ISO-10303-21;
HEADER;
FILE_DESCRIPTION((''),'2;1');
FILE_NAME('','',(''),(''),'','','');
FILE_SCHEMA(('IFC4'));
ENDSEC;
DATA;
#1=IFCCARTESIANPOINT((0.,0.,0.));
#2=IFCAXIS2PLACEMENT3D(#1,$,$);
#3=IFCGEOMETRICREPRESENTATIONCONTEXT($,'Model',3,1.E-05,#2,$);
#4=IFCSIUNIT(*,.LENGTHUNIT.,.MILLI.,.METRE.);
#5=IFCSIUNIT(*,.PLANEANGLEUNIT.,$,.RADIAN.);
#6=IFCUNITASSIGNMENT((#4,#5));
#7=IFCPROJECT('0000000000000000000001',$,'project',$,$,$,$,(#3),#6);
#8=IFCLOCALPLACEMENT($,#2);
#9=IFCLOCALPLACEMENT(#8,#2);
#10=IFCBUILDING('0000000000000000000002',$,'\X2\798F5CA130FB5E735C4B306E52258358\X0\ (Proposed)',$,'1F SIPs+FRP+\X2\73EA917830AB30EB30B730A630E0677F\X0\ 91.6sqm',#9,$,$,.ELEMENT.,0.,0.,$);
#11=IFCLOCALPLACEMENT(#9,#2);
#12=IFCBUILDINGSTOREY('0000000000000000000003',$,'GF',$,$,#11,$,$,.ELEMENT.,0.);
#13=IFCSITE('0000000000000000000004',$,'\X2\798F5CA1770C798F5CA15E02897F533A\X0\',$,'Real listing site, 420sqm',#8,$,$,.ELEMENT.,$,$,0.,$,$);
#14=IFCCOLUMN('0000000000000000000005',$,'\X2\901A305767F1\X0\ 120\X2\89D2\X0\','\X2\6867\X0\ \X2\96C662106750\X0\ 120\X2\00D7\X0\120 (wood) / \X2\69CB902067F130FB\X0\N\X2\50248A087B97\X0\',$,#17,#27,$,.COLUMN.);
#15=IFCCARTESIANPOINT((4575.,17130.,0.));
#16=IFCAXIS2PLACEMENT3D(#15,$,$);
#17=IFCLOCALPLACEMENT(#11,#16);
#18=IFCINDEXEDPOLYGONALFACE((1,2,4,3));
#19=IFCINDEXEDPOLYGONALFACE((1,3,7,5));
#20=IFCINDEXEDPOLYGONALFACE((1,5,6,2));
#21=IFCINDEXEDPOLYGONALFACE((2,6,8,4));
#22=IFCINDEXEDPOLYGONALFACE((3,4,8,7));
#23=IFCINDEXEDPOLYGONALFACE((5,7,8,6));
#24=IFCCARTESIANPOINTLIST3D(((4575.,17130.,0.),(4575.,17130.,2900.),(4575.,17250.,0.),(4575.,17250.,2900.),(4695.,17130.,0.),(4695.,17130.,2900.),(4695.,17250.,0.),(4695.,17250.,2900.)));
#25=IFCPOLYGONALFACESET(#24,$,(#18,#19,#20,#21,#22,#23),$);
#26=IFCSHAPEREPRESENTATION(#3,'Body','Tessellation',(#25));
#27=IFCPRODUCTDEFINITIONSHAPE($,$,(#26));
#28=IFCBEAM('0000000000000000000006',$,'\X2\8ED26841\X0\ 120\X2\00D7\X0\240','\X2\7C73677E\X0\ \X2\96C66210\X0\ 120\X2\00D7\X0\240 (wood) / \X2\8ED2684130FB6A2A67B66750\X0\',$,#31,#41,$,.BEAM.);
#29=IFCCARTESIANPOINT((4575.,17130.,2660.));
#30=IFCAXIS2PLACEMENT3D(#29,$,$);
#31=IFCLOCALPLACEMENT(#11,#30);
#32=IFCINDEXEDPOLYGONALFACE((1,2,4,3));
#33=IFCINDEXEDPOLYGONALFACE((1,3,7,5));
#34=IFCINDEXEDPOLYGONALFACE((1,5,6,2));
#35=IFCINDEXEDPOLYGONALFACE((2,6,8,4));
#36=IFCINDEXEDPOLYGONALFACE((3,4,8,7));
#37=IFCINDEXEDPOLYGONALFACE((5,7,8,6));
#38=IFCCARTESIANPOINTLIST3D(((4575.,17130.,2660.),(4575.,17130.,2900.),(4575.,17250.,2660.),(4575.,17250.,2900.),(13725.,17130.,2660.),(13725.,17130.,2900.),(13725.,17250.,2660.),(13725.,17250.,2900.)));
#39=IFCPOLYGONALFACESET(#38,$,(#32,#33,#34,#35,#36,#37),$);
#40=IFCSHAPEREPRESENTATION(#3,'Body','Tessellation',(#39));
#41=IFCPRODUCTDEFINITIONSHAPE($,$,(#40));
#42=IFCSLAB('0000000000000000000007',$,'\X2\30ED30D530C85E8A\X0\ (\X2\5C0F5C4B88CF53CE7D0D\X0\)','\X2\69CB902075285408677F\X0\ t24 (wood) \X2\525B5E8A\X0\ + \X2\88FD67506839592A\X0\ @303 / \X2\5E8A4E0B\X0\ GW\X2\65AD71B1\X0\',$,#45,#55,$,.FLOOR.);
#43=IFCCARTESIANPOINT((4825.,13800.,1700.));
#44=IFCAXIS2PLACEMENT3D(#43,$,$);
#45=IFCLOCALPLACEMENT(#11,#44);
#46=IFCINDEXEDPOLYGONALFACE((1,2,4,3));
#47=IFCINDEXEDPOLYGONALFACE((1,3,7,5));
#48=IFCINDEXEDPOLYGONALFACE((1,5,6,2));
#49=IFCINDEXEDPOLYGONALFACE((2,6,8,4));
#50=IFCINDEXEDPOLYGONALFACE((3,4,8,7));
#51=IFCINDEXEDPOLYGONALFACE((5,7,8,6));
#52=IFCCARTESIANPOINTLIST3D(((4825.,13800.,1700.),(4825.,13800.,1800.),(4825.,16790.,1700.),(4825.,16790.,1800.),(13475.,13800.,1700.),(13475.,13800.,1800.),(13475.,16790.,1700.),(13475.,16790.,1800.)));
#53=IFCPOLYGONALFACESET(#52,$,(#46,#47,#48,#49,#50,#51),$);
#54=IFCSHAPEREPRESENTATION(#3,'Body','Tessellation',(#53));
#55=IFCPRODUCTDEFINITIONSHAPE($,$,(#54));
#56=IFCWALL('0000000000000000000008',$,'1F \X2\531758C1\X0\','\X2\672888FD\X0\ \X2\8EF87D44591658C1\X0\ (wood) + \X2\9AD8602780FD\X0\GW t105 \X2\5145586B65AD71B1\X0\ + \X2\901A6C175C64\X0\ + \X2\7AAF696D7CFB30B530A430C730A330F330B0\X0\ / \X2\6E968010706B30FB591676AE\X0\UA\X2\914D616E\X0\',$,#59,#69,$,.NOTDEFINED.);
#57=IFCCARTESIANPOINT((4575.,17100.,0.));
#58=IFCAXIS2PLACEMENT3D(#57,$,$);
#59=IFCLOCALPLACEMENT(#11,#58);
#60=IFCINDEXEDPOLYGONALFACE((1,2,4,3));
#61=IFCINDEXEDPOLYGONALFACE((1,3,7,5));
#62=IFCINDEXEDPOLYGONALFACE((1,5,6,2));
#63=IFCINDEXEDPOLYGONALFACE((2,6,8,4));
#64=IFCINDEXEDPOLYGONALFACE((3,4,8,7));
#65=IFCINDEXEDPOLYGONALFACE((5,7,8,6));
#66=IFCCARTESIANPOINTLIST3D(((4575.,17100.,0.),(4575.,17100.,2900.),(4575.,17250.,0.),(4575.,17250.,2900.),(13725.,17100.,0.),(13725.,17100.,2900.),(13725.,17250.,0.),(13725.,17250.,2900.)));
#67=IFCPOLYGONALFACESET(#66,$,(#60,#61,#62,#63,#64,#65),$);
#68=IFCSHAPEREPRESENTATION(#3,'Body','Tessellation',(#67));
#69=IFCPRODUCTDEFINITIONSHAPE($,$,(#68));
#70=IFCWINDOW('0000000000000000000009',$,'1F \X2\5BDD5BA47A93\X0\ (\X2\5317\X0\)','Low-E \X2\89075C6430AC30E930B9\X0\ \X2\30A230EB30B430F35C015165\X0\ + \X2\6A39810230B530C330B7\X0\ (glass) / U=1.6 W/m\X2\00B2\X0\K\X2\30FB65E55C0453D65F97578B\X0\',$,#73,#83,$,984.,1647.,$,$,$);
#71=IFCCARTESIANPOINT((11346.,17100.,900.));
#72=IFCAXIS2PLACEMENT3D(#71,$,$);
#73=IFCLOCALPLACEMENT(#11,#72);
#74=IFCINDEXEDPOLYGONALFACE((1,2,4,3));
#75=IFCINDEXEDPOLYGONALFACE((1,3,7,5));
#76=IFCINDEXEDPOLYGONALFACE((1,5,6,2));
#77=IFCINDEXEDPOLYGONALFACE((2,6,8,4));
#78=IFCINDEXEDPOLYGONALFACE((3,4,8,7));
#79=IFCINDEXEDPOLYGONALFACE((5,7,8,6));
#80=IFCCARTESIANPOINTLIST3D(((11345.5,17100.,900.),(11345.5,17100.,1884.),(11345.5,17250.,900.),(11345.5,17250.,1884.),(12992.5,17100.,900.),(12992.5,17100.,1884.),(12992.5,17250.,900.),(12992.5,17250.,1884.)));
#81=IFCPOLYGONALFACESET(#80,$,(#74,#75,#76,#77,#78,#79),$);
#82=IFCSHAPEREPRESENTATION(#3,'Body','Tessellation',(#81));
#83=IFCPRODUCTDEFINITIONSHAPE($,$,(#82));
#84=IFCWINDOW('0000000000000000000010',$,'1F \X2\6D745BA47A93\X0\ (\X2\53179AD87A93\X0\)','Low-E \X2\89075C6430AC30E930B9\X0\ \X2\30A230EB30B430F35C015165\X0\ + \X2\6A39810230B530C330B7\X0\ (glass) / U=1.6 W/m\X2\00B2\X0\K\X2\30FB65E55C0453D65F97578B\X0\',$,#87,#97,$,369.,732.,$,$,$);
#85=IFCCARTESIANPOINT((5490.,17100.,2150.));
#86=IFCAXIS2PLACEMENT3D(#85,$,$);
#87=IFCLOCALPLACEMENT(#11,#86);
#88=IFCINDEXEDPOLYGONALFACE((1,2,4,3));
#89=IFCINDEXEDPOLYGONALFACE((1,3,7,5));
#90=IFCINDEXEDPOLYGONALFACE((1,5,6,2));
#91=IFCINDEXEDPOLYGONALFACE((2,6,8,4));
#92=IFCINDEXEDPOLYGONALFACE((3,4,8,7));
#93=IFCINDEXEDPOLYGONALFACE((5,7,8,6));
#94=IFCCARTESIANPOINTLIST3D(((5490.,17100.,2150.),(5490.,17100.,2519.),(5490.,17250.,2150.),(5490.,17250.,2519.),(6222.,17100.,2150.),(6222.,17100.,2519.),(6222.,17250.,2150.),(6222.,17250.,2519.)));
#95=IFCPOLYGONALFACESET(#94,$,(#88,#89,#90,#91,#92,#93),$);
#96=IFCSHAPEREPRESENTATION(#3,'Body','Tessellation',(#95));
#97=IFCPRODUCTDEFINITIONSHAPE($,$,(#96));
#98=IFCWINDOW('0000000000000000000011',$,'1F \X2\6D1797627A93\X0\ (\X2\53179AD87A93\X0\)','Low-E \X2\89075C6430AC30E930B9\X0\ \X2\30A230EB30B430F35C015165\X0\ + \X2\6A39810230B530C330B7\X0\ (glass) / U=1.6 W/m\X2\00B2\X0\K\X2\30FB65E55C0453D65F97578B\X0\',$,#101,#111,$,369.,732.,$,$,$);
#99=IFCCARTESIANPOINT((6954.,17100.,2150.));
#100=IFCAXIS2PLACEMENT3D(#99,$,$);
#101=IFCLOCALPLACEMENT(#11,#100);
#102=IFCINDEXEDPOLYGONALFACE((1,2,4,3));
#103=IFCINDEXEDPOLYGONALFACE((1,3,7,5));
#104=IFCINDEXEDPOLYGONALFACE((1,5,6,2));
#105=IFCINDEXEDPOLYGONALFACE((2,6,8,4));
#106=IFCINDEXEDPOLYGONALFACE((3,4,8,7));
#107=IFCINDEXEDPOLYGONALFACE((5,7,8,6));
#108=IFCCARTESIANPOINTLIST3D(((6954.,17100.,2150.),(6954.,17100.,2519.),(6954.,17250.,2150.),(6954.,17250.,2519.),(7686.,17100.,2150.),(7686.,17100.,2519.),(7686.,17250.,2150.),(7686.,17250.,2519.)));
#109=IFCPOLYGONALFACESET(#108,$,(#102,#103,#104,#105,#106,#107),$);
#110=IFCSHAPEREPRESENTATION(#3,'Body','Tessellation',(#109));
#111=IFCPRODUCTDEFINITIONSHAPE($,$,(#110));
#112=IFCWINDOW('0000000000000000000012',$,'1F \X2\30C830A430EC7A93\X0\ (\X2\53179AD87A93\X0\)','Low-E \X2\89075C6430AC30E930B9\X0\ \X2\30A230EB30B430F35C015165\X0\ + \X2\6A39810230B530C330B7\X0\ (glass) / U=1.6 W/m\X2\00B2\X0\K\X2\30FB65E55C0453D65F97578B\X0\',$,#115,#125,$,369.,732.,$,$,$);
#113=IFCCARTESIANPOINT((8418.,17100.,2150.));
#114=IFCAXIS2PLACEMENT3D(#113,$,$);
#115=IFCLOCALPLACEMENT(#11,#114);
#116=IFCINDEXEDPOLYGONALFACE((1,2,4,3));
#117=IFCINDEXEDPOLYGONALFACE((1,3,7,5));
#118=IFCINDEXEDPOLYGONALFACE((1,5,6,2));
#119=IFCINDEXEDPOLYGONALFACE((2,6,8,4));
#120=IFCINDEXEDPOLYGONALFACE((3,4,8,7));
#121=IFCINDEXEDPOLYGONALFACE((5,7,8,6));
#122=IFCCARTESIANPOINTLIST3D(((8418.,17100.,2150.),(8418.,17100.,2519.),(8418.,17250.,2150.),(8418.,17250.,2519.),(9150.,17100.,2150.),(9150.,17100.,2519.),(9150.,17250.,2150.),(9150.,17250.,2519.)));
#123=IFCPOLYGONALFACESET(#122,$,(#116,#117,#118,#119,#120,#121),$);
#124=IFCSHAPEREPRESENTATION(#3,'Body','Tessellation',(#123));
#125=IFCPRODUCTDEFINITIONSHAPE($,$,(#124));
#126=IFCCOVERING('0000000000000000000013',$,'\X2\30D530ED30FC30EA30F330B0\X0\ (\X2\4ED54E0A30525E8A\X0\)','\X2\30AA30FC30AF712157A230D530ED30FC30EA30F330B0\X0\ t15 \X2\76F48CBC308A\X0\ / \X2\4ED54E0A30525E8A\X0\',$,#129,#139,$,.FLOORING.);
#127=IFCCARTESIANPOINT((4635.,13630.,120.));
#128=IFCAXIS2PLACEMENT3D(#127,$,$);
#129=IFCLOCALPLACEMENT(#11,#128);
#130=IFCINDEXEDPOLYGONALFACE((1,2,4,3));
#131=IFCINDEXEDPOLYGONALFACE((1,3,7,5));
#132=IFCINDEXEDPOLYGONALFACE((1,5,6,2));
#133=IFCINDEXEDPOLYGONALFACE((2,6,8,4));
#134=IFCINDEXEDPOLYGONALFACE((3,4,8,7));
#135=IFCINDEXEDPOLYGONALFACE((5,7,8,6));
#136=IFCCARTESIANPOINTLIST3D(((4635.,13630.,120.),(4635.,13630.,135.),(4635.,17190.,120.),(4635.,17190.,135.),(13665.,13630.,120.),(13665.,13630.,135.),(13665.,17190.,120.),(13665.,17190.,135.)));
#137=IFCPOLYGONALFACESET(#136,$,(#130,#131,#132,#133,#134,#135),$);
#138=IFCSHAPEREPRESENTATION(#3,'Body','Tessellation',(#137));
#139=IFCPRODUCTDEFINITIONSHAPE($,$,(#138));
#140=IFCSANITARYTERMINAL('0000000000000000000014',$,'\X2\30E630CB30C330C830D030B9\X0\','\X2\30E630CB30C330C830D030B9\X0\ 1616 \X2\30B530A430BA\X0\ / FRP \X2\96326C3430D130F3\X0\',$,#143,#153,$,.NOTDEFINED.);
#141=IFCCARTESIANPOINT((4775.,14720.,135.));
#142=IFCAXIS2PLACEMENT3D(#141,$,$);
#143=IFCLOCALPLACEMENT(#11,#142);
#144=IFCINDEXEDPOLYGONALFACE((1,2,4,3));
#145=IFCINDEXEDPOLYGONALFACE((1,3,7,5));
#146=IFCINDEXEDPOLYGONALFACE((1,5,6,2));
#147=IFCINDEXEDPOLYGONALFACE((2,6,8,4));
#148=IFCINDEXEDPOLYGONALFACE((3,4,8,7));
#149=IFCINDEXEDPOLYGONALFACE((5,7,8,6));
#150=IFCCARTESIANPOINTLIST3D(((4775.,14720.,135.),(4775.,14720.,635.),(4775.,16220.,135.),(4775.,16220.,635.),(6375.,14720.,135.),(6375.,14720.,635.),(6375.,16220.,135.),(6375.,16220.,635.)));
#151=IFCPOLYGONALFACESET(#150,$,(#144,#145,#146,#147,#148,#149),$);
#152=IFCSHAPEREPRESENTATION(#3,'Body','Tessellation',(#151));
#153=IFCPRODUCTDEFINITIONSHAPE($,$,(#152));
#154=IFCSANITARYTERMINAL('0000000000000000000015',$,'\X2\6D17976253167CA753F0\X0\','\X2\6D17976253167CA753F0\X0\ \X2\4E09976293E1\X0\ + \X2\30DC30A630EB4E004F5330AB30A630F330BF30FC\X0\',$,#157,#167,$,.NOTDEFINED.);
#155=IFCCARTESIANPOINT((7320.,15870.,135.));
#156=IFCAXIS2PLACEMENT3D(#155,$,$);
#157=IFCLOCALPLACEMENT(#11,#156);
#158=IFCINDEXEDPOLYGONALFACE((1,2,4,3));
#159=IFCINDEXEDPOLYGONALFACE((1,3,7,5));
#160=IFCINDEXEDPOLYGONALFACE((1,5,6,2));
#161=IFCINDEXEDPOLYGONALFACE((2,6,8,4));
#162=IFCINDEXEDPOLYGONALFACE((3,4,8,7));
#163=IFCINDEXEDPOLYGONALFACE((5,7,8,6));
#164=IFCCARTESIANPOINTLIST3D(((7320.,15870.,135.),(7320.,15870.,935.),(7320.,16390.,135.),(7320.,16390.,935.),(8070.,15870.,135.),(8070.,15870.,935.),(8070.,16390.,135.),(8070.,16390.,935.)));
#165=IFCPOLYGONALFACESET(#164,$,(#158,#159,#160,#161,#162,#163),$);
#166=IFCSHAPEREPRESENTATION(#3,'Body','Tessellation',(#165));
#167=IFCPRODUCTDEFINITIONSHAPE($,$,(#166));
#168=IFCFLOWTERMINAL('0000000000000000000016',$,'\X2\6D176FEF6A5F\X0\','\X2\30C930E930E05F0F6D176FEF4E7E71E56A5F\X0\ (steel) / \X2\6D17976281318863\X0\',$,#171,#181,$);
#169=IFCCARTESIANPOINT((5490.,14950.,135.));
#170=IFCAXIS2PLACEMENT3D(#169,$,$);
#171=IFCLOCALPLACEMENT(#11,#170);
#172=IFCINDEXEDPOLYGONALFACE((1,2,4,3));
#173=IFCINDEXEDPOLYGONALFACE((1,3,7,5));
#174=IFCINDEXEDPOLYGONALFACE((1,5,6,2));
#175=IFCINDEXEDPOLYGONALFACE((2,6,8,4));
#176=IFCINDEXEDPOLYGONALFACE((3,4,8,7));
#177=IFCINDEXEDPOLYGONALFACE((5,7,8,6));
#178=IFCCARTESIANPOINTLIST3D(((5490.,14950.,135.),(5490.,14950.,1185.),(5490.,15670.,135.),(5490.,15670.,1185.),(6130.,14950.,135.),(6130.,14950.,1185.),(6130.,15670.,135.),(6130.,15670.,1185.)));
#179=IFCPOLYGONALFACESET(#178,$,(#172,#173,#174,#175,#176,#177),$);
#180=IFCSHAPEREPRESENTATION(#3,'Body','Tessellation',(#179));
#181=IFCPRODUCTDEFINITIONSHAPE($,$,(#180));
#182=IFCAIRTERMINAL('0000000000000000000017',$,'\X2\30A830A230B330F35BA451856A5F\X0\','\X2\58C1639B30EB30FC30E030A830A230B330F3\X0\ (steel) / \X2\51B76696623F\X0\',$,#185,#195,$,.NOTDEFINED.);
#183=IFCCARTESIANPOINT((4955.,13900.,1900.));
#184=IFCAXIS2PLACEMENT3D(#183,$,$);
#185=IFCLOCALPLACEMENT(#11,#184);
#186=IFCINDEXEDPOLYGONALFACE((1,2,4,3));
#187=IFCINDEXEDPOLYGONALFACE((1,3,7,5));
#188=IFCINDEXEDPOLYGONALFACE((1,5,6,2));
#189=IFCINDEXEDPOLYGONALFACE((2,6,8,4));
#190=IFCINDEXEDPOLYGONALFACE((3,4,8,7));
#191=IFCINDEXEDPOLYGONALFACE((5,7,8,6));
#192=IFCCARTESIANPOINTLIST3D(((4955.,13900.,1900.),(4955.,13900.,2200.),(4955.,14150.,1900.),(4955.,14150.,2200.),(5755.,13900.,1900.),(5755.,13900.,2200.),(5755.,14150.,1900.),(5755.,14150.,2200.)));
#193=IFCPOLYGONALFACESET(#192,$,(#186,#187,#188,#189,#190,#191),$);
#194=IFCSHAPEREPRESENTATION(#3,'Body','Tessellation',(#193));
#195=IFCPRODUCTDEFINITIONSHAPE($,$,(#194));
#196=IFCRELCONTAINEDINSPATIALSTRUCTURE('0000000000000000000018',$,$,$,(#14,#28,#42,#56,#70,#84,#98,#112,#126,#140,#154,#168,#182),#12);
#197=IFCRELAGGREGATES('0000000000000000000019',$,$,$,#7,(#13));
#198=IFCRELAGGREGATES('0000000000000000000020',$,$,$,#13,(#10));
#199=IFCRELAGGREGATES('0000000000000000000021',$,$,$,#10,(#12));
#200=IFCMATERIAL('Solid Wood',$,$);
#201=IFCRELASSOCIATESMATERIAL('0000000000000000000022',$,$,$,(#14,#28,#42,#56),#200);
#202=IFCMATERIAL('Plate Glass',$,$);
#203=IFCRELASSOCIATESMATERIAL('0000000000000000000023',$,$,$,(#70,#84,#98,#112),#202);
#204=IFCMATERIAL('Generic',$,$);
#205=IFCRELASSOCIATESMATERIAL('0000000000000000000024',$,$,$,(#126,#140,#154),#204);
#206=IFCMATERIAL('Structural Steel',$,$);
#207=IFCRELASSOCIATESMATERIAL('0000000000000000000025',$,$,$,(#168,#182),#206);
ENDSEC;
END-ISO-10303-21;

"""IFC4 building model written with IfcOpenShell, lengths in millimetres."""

from ifc_helpers import new_model, si_unit, frame, frame_2d, origin, place, context, project, spatial, rectangle, extrude, material, element, fill, save


model = new_model("IFC4")

# Units and contexts
model_context = context("Model", 3, precision=1e-05, world=origin())
ifc_project = project(units=[si_unit("LENGTHUNIT", "METRE", prefix="MILLI"), si_unit("PLANEANGLEUNIT", "RADIAN")], contexts=[model_context])

# Site, building, storey
site_placement = place(None, origin())
site = spatial("IfcSite", under=ifc_project, at=site_placement, Name="福岡県福岡市西区", ObjectType="Real listing site, 420sqm", CompositionType="ELEMENT", RefElevation=0.0)
building_placement = place(site_placement, origin())
building = spatial("IfcBuilding", under=site, at=building_placement, Name="福岡・平屋の別荘 (Proposed)", ObjectType="1F SIPs+FRP+珪酸カルシウム板 91.6sqm", CompositionType="ELEMENT", ElevationOfRefHeight=0.0, ElevationOfTerrain=0.0)
storey_placement = place(building_placement, origin())
storey = spatial("IfcBuildingStorey", under=building, at=storey_placement, Name="GF", CompositionType="ELEMENT", Elevation=0.0)

# Column
ifc_material_1 = material(Name="Solid Wood")
column_1_placement = place(storey_placement, frame((4575.0, 17130.0, 0.0)))
element("IfcColumn", 1, at=column_1_placement, inside=storey, material=ifc_material_1, Name="通し柱 120角", Description="桧 集成材 120×120 (wood) / 構造柱・N値計算", PredefinedType="COLUMN", context=model_context, shape_type="SweptSolid", body=[
    extrude(rectangle(XDim=120.0, YDim=120.0, at=frame_2d((60.0, 60.0))), frame((4575.0, 17130.0, 0.0)), (0.0, 0.0, 1.0), 2900.0),
])

# Beam
beam_1_placement = place(storey_placement, frame((4575.0, 17130.0, 2660.0)))
element("IfcBeam", 2, at=beam_1_placement, inside=storey, material=ifc_material_1, Name="軒桁 120×240", Description="米松 集成 120×240 (wood) / 軒桁・横架材", PredefinedType="BEAM", context=model_context, shape_type="SweptSolid", body=[
    extrude(rectangle(XDim=9150.0, YDim=120.0, at=frame_2d((4575.0, 60.0))), frame((4575.0, 17130.0, 2660.0)), (0.0, 0.0, 1.0), 240.0),
])

# Slab
slab_placement = place(storey_placement, frame((4825.0, 13800.0, 1700.0)))
element("IfcSlab", 3, at=slab_placement, inside=storey, material=ifc_material_1, Name="ロフト床 (小屋裏収納)", Description="構造用合板 t24 (wood) 剛床 + 製材根太 @303 / 床下 GW断熱", PredefinedType="FLOOR", context=model_context, shape_type="SweptSolid", body=[
    extrude(rectangle(XDim=8650.0, YDim=2990.0, at=frame_2d((4325.0, 1495.0))), frame((4825.0, 13800.0, 1700.0)), (0.0, 0.0, 1.0), 100.0),
])

# Wall, openings, windows
wall_1_placement = place(storey_placement, frame((4575.0, 17100.0, 0.0)))
wall_1 = element("IfcWall", 4, at=wall_1_placement, inside=storey, material=ifc_material_1, Name="1F 北壁", Description="木製 軸組外壁 (wood) + 高性能GW t105 充填断熱 + 通気層 + 窯業系サイディング / 準耐火・外皮UA配慮", PredefinedType="NOTDEFINED", context=model_context, shape_type="SweptSolid", body=[
    extrude(rectangle(XDim=9150.0, YDim=150.0, at=frame_2d((4575.0, 75.0))), frame((4575.0, 17100.0, 0.0)), (0.0, 0.0, 1.0), 2900.0),
])
opening_1_placement = place(storey_placement, frame((11346.0, 17100.0, 900.0)))
opening_1 = element("IfcOpeningElement", 5, at=opening_1_placement, cuts=wall_1, PredefinedType="NOTDEFINED", context=model_context, shape_type="SweptSolid", body=[
    extrude(rectangle(XDim=1647.0, YDim=150.0, at=frame_2d((823.0, 75.0))), frame((11346.0, 17100.0, 900.0)), (0.0, 0.0, 1.0), 984.0),
])
opening_2_placement = place(storey_placement, frame((5490.0, 17100.0, 2150.0)))
opening_2 = element("IfcOpeningElement", 6, at=opening_2_placement, cuts=wall_1, PredefinedType="NOTDEFINED", context=model_context, shape_type="SweptSolid", body=[
    extrude(rectangle(XDim=732.0, YDim=150.0, at=frame_2d((366.0, 75.0))), frame((5490.0, 17100.0, 2150.0)), (0.0, 0.0, 1.0), 369.0),
])
opening_3_placement = place(storey_placement, frame((6954.0, 17100.0, 2150.0)))
opening_3 = element("IfcOpeningElement", 7, at=opening_3_placement, cuts=wall_1, PredefinedType="NOTDEFINED", context=model_context, shape_type="SweptSolid", body=[
    extrude(rectangle(XDim=732.0, YDim=150.0, at=frame_2d((366.0, 75.0))), frame((6954.0, 17100.0, 2150.0)), (0.0, 0.0, 1.0), 369.0),
])
opening_4_placement = place(storey_placement, frame((8418.0, 17100.0, 2150.0)))
opening_4 = element("IfcOpeningElement", 8, at=opening_4_placement, cuts=wall_1, PredefinedType="NOTDEFINED", context=model_context, shape_type="SweptSolid", body=[
    extrude(rectangle(XDim=732.0, YDim=150.0, at=frame_2d((366.0, 75.0))), frame((8418.0, 17100.0, 2150.0)), (0.0, 0.0, 1.0), 369.0),
])
ifc_material_2 = material(Name="Plate Glass")
window_1_placement = place(storey_placement, frame((11346.0, 17100.0, 900.0)))
window_1 = element("IfcWindow", 9, at=window_1_placement, inside=storey, material=ifc_material_2, Name="1F 寝室窓 (北)", Description="Low-E 複層ガラス アルゴン封入 + 樹脂サッシ (glass) / U=1.6 W/m²K・日射取得型", OverallHeight=984.0, OverallWidth=1647.0, context=model_context, shape_type="SweptSolid", body=[
    extrude(rectangle(XDim=1647.0, YDim=150.0, at=frame_2d((823.0, 75.0))), frame((11346.0, 17100.0, 900.0)), (0.0, 0.0, 1.0), 984.0),
])
fill(opening_1, window_1)
window_2_placement = place(storey_placement, frame((5490.0, 17100.0, 2150.0)))
window_2 = element("IfcWindow", 10, at=window_2_placement, inside=storey, material=ifc_material_2, Name="1F 浴室窓 (北高窓)", Description="Low-E 複層ガラス アルゴン封入 + 樹脂サッシ (glass) / U=1.6 W/m²K・日射取得型", OverallHeight=369.0, OverallWidth=732.0, context=model_context, shape_type="SweptSolid", body=[
    extrude(rectangle(XDim=732.0, YDim=150.0, at=frame_2d((366.0, 75.0))), frame((5490.0, 17100.0, 2150.0)), (0.0, 0.0, 1.0), 369.0),
])
fill(opening_2, window_2)
window_3_placement = place(storey_placement, frame((6954.0, 17100.0, 2150.0)))
window_3 = element("IfcWindow", 11, at=window_3_placement, inside=storey, material=ifc_material_2, Name="1F 洗面窓 (北高窓)", Description="Low-E 複層ガラス アルゴン封入 + 樹脂サッシ (glass) / U=1.6 W/m²K・日射取得型", OverallHeight=369.0, OverallWidth=732.0, context=model_context, shape_type="SweptSolid", body=[
    extrude(rectangle(XDim=732.0, YDim=150.0, at=frame_2d((366.0, 75.0))), frame((6954.0, 17100.0, 2150.0)), (0.0, 0.0, 1.0), 369.0),
])
fill(opening_3, window_3)
window_4_placement = place(storey_placement, frame((8418.0, 17100.0, 2150.0)))
window_4 = element("IfcWindow", 12, at=window_4_placement, inside=storey, material=ifc_material_2, Name="1F トイレ窓 (北高窓)", Description="Low-E 複層ガラス アルゴン封入 + 樹脂サッシ (glass) / U=1.6 W/m²K・日射取得型", OverallHeight=369.0, OverallWidth=732.0, context=model_context, shape_type="SweptSolid", body=[
    extrude(rectangle(XDim=732.0, YDim=150.0, at=frame_2d((366.0, 75.0))), frame((8418.0, 17100.0, 2150.0)), (0.0, 0.0, 1.0), 369.0),
])
fill(opening_4, window_4)

# Covering
ifc_material_3 = material(Name="Generic")
covering_placement = place(storey_placement, frame((4635.0, 13630.0, 120.0)))
element("IfcCovering", 13, at=covering_placement, inside=storey, material=ifc_material_3, Name="フローリング (仕上げ床)", Description="オーク無垢フローリング t15 直貼り / 仕上げ床", PredefinedType="FLOORING", context=model_context, shape_type="SweptSolid", body=[
    extrude(rectangle(XDim=9030.0, YDim=3560.0, at=frame_2d((4515.0, 1780.0))), frame((4635.0, 13630.0, 120.0)), (0.0, 0.0, 1.0), 15.0),
])

# Sanitary terminals
sanitary_terminal_1_placement = place(storey_placement, frame((4775.0, 14720.0, 135.0)))
element("IfcSanitaryTerminal", 14, at=sanitary_terminal_1_placement, inside=storey, material=ifc_material_3, Name="ユニットバス", Description="ユニットバス 1616 サイズ / FRP 防水パン", PredefinedType="NOTDEFINED", context=model_context, shape_type="SweptSolid", body=[
    extrude(rectangle(XDim=1600.0, YDim=1500.0, at=frame_2d((800.0, 750.0))), frame((4775.0, 14720.0, 135.0)), (0.0, 0.0, 1.0), 500.0),
])
sanitary_terminal_2_placement = place(storey_placement, frame((7320.0, 15870.0, 135.0)))
element("IfcSanitaryTerminal", 15, at=sanitary_terminal_2_placement, inside=storey, material=ifc_material_3, Name="洗面化粧台", Description="洗面化粧台 三面鏡 + ボウル一体カウンター", PredefinedType="NOTDEFINED", context=model_context, shape_type="SweptSolid", body=[
    extrude(rectangle(XDim=750.0, YDim=520.0, at=frame_2d((375.0, 260.0))), frame((7320.0, 15870.0, 135.0)), (0.0, 0.0, 1.0), 800.0),
])

# Flow terminal
ifc_material_4 = material(Name="Structural Steel")
flow_terminal_placement = place(storey_placement, frame((5490.0, 14950.0, 135.0)))
element("IfcFlowTerminal", 16, at=flow_terminal_placement, inside=storey, material=ifc_material_4, Name="洗濯機", Description="ドラム式洗濯乾燥機 (steel) / 洗面脱衣", context=model_context, shape_type="SweptSolid", body=[
    extrude(rectangle(XDim=640.0, YDim=720.0, at=frame_2d((320.0, 360.0))), frame((5490.0, 14950.0, 135.0)), (0.0, 0.0, 1.0), 1050.0),
])

# Air terminal
air_terminal_placement = place(storey_placement, frame((4955.0, 13900.0, 1900.0)))
element("IfcAirTerminal", 17, at=air_terminal_placement, inside=storey, material=ifc_material_4, Name="エアコン室内機", Description="壁掛ルームエアコン (steel) / 冷暖房", PredefinedType="NOTDEFINED", context=model_context, shape_type="SweptSolid", body=[
    extrude(rectangle(XDim=800.0, YDim=250.0, at=frame_2d((400.0, 125.0))), frame((4955.0, 13900.0, 1900.0)), (0.0, 0.0, 1.0), 300.0),
])

save(model, "model.ifc")
